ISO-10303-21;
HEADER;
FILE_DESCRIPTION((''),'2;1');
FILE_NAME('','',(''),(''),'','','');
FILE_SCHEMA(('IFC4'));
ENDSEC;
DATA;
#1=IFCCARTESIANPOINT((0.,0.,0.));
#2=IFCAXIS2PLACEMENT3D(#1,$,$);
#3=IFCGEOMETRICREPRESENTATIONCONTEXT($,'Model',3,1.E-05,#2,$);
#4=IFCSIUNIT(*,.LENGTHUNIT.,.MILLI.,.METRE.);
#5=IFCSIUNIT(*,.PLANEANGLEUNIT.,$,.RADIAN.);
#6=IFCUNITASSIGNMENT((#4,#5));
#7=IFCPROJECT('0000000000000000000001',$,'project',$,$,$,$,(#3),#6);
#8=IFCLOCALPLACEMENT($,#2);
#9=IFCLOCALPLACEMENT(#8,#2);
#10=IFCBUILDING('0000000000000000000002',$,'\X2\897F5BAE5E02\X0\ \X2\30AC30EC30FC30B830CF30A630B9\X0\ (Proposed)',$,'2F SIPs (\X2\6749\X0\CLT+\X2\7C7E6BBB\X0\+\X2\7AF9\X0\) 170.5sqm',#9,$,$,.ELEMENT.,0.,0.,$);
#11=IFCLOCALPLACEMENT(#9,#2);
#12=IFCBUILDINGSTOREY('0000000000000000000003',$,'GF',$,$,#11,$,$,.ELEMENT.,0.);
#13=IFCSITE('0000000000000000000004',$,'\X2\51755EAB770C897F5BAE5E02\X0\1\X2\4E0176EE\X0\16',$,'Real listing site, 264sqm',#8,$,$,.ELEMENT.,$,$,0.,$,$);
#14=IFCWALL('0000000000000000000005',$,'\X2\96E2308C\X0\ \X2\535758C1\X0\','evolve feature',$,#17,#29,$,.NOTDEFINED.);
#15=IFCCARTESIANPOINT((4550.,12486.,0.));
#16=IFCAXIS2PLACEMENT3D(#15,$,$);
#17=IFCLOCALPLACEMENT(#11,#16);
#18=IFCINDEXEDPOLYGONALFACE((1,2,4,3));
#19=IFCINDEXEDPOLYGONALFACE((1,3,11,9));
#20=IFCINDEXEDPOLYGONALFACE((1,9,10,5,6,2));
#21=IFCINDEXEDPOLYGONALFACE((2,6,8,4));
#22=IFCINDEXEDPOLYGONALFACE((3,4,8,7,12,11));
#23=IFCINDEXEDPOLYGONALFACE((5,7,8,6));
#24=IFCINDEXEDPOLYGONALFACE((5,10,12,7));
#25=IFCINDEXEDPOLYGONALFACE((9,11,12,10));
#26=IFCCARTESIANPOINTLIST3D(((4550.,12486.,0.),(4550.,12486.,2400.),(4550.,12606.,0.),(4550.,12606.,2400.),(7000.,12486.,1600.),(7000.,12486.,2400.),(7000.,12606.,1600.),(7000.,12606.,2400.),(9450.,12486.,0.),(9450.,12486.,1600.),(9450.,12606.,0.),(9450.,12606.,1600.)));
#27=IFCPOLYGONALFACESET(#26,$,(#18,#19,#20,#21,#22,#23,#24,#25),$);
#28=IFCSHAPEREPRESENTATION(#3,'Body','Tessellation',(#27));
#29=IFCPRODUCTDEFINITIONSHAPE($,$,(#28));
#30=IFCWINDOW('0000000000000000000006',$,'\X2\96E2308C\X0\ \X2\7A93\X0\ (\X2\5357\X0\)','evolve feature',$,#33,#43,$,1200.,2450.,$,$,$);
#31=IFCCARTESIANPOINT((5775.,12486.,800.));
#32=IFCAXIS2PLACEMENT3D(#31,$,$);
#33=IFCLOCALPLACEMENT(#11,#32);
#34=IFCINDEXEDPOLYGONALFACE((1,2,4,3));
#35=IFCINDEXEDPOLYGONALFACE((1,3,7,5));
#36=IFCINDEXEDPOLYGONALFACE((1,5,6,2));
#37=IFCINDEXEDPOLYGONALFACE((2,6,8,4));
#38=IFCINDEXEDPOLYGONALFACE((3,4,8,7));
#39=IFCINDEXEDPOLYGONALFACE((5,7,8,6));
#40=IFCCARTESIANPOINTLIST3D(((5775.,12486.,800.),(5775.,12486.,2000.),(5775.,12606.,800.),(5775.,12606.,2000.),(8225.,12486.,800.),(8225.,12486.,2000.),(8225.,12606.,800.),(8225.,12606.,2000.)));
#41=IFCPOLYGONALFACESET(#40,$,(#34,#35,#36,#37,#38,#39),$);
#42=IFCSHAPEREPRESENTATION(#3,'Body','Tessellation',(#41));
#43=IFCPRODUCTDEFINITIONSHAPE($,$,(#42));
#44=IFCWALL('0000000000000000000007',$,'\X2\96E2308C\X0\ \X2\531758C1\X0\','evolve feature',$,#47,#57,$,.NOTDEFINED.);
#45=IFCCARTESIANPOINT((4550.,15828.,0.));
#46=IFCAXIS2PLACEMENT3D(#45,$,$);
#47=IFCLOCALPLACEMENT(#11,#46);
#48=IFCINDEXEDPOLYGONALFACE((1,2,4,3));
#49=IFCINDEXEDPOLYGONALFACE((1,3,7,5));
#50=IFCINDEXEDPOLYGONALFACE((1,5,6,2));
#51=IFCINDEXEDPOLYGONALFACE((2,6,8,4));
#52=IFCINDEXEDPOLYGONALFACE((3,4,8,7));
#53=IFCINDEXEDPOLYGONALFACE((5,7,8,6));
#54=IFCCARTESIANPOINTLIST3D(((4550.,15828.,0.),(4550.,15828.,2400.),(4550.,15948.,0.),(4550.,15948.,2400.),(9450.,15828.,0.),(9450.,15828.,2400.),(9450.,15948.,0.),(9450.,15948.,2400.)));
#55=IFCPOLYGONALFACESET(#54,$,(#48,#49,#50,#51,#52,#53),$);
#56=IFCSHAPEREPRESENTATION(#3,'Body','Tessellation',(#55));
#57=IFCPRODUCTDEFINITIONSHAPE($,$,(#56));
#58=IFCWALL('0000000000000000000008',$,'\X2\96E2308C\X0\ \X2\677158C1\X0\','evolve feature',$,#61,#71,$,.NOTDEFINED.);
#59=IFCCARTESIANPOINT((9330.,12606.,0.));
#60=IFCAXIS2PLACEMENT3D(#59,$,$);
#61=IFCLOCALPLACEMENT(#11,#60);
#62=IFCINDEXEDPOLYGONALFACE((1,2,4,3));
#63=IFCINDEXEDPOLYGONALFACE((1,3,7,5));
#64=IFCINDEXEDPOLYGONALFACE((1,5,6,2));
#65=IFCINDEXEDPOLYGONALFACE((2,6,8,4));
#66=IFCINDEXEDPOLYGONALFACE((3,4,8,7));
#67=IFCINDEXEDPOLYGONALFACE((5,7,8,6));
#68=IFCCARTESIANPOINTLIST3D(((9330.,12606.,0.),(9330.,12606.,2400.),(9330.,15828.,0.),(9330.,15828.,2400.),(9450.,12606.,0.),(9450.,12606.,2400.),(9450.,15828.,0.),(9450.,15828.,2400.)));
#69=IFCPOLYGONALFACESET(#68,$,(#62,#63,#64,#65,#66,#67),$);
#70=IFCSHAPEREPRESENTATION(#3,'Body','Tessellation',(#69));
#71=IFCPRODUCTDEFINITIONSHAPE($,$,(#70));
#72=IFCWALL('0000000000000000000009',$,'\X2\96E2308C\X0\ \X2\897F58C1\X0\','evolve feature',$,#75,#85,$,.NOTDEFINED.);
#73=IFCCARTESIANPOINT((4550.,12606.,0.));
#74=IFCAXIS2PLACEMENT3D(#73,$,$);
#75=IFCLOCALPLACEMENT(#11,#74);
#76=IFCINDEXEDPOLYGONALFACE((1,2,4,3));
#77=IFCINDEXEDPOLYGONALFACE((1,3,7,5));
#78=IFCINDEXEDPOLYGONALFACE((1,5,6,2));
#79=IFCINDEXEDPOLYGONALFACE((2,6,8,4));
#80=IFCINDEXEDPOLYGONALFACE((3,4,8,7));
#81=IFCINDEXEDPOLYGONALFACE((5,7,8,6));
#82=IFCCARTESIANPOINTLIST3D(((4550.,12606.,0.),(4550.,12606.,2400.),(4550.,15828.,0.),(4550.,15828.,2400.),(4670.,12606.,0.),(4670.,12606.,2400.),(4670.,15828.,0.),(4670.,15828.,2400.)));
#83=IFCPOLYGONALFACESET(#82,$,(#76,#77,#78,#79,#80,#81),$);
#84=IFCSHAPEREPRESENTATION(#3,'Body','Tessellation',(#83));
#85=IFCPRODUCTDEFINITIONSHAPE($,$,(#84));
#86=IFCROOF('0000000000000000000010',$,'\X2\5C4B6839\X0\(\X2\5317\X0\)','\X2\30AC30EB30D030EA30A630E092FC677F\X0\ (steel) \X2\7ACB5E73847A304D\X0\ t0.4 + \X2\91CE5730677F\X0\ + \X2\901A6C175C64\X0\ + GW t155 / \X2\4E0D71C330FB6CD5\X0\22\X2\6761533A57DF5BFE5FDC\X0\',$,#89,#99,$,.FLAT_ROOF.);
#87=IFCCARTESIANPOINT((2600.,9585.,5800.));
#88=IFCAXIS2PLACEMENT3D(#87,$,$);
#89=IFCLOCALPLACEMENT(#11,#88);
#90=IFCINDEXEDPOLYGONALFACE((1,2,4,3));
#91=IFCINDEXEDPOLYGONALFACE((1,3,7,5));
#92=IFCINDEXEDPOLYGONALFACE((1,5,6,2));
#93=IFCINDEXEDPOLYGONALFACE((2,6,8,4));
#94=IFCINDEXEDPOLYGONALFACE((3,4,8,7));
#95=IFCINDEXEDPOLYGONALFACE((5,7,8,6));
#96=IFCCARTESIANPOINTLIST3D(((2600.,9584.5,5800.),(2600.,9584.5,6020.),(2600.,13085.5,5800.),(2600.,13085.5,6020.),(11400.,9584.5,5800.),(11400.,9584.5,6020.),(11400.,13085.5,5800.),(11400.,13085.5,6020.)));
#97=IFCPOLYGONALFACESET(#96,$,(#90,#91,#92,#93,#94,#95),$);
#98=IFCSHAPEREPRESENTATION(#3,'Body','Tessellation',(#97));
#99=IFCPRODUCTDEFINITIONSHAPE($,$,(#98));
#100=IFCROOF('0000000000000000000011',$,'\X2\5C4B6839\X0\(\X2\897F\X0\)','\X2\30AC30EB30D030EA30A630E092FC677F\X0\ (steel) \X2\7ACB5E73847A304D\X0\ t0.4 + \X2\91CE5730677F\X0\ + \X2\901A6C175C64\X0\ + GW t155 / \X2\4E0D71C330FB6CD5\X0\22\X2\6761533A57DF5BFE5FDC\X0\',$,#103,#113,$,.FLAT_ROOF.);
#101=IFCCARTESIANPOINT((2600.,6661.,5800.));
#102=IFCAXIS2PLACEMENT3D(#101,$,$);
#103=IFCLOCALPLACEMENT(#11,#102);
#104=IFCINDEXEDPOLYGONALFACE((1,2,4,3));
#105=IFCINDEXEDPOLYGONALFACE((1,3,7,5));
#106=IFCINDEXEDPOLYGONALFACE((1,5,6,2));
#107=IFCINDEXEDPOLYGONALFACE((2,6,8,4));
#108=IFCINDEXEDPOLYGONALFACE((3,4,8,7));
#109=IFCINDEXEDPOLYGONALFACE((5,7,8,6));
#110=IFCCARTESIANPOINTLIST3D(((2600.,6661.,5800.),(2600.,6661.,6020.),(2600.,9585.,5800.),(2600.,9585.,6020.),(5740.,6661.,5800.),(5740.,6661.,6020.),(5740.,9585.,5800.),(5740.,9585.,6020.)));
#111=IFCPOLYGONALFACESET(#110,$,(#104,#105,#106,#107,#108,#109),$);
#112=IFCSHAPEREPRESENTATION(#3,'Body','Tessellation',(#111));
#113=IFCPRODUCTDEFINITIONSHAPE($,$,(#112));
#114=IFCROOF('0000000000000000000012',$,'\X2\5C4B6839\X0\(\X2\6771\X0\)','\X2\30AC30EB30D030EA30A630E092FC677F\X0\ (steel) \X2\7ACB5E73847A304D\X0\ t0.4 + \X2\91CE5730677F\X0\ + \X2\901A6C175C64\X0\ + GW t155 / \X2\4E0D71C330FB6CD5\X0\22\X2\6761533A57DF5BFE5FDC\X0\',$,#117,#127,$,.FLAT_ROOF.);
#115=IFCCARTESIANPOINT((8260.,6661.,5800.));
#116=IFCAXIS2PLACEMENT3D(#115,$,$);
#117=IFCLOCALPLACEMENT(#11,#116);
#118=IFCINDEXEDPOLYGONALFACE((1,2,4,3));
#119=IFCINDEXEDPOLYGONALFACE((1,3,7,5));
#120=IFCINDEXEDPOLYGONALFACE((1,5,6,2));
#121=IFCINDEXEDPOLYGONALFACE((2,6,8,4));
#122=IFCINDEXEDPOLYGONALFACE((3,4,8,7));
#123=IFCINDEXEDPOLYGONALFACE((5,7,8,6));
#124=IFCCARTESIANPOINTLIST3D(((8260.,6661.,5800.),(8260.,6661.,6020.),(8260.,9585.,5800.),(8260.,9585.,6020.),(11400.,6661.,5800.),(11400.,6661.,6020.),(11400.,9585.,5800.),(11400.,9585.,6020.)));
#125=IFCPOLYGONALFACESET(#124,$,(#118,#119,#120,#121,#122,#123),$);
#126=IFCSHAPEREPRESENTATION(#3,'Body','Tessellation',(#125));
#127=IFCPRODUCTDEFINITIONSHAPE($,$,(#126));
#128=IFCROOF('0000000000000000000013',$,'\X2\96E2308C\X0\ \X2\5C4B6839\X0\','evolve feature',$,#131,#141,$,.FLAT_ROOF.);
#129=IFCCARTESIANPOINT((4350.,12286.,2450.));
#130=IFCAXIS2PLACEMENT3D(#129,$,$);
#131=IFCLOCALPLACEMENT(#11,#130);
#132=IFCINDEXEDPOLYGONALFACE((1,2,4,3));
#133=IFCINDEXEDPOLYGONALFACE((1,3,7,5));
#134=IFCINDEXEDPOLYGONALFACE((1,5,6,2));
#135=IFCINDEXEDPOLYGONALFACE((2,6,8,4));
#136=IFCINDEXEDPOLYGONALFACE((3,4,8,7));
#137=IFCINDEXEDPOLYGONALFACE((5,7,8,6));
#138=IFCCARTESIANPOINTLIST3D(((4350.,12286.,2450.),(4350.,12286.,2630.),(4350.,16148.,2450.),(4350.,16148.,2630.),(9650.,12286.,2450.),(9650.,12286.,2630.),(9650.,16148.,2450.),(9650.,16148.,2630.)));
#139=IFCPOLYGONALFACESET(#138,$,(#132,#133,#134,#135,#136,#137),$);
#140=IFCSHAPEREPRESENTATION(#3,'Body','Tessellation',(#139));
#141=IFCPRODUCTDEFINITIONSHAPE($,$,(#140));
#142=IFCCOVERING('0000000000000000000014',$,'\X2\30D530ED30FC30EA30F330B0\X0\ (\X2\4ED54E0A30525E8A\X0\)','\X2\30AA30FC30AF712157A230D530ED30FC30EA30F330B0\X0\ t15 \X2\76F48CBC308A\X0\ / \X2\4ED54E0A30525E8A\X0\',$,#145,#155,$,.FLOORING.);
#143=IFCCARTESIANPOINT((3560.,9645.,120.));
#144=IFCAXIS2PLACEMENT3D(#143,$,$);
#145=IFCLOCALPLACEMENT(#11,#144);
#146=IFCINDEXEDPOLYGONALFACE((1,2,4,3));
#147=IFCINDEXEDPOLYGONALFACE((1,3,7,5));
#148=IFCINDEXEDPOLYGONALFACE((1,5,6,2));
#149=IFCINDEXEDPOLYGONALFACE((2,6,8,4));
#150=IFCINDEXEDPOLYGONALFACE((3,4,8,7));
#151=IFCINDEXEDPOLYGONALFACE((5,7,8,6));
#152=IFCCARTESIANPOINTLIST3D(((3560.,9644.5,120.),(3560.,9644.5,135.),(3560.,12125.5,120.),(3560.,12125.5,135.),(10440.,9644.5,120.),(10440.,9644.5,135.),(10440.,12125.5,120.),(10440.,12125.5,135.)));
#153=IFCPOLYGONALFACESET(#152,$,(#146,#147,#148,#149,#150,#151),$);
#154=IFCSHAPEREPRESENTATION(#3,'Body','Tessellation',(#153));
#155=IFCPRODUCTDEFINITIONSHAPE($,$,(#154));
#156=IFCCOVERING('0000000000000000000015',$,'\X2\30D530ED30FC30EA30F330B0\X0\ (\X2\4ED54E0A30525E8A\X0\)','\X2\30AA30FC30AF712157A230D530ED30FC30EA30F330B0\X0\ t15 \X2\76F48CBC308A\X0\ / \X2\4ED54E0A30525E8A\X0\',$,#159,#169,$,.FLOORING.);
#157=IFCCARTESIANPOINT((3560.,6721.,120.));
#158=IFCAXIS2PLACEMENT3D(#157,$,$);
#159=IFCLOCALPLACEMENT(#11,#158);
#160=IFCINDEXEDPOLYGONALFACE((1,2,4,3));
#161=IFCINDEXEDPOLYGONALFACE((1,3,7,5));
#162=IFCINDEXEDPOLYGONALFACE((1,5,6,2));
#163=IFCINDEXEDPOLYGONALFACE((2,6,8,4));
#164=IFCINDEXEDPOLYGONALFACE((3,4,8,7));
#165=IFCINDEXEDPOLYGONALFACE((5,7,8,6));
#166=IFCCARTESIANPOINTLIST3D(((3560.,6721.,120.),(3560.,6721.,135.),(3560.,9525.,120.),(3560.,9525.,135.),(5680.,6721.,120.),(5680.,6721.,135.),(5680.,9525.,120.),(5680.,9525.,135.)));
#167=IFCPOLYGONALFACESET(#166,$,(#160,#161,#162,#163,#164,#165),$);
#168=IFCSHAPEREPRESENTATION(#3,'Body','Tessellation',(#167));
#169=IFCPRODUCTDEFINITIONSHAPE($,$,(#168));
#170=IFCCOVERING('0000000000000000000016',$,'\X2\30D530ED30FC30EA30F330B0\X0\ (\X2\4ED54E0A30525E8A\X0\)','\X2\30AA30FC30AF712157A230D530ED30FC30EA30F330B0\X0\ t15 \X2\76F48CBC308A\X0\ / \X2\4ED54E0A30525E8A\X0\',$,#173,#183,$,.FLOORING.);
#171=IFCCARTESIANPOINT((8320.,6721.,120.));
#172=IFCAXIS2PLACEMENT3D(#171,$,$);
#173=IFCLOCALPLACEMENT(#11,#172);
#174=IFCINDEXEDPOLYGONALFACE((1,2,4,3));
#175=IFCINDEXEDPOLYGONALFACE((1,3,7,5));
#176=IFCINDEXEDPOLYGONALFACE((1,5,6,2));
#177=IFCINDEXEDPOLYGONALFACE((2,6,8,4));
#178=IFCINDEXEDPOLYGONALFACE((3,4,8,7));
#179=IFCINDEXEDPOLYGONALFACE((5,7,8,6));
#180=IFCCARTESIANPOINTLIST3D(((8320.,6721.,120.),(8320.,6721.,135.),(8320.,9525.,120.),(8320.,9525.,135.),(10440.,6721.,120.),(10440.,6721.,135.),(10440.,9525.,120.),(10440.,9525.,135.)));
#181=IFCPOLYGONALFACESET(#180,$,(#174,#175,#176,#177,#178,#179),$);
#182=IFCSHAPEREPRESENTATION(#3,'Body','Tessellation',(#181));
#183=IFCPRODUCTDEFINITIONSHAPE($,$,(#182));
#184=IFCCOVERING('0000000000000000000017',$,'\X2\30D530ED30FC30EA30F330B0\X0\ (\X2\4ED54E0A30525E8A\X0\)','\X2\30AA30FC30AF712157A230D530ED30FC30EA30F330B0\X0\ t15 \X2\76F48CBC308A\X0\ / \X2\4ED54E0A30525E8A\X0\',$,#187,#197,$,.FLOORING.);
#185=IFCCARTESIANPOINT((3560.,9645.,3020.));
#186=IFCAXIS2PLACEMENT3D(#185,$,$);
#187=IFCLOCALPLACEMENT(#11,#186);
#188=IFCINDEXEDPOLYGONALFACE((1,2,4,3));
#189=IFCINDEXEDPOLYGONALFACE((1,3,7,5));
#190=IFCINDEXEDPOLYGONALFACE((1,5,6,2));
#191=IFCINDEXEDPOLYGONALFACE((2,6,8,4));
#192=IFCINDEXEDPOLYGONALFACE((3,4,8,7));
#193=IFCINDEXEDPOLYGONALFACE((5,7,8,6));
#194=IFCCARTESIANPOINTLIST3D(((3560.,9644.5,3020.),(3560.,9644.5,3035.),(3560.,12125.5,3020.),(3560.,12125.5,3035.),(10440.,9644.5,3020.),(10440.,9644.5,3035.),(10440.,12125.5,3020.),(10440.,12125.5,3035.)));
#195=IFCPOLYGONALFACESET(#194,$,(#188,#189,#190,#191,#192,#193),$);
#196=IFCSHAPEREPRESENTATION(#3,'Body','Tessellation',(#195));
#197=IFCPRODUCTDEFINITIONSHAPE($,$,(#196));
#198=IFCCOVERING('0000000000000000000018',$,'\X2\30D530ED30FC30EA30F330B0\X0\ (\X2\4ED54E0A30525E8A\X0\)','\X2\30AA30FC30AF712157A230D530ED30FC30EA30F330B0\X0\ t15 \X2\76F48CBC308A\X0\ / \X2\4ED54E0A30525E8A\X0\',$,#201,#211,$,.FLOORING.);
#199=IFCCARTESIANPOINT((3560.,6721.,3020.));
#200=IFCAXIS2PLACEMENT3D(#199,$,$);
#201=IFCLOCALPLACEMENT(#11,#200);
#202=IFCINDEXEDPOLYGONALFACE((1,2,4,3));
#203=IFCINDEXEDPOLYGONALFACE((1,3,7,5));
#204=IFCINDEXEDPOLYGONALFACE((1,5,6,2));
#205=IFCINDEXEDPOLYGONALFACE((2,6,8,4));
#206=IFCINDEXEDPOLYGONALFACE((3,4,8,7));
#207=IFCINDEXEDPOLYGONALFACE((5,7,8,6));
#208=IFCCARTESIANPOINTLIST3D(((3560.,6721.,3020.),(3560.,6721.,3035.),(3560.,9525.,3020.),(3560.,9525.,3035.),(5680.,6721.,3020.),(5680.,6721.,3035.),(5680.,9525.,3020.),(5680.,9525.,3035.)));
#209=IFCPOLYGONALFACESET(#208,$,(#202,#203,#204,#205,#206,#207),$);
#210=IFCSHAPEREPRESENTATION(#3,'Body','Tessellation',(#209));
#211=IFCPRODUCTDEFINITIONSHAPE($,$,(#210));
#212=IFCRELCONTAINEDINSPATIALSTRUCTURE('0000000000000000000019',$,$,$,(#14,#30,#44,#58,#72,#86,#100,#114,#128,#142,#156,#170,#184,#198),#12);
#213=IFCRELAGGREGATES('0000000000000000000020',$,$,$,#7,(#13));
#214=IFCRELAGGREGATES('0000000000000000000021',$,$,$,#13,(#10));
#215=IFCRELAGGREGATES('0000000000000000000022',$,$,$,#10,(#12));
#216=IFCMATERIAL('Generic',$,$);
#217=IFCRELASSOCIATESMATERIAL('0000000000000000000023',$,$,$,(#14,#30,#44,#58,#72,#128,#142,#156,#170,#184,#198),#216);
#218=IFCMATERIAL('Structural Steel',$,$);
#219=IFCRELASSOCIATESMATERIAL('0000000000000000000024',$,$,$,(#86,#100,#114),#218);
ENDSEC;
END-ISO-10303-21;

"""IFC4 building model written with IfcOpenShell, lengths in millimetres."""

from ifc_helpers import new_model, si_unit, frame, frame_2d, origin, place, context, project, spatial, rectangle, extrude, material, element, fill, save


model = new_model("IFC4")

# Units and contexts
model_context = context("Model", 3, precision=1e-05, world=origin())
ifc_project = project(units=[si_unit("LENGTHUNIT", "METRE", prefix="MILLI"), si_unit("PLANEANGLEUNIT", "RADIAN")], contexts=[model_context])

# Site, building, storey
site_placement = place(None, origin())
site = spatial("IfcSite", under=ifc_project, at=site_placement, Name="兵庫県西宮市1丁目16", ObjectType="Real listing site, 264sqm", CompositionType="ELEMENT", RefElevation=0.0)
building_placement = place(site_placement, origin())
building = spatial("IfcBuilding", under=site, at=building_placement, Name="西宮市 ガレージハウス (Proposed)", ObjectType="2F SIPs (杉CLT+籾殻+竹) 170.5sqm", CompositionType="ELEMENT", ElevationOfRefHeight=0.0, ElevationOfTerrain=0.0)
storey_placement = place(building_placement, origin())
storey = spatial("IfcBuildingStorey", under=building, at=storey_placement, Name="GF", CompositionType="ELEMENT", Elevation=0.0)

# Shared definitions
ifc_material_1 = material(Name="Generic")

# Wall, opening, window
wall_1_placement = place(storey_placement, frame((4550.0, 12486.0, 0.0)))
wall_1 = element("IfcWall", 1, at=wall_1_placement, inside=storey, material=ifc_material_1, Name="離れ 南壁", Description="evolve feature", PredefinedType="NOTDEFINED", context=model_context, shape_type="SweptSolid", body=[
    extrude(rectangle(XDim=4900.0, YDim=120.0, at=frame_2d((2450.0, 60.0))), frame((4550.0, 12486.0, 0.0)), (0.0, 0.0, 1.0), 2400.0),
])
opening_1_placement = place(storey_placement, frame((5775.0, 12486.0, 800.0)))
opening_1 = element("IfcOpeningElement", 2, at=opening_1_placement, cuts=wall_1, PredefinedType="NOTDEFINED", context=model_context, shape_type="SweptSolid", body=[
    extrude(rectangle(XDim=2450.0, YDim=120.0, at=frame_2d((1225.0, 60.0))), frame((5775.0, 12486.0, 800.0)), (0.0, 0.0, 1.0), 1200.0),
])
window_1_placement = place(storey_placement, frame((5775.0, 12486.0, 800.0)))
window_1 = element("IfcWindow", 3, at=window_1_placement, inside=storey, material=ifc_material_1, Name="離れ 窓 (南)", Description="evolve feature", OverallHeight=1200.0, OverallWidth=2450.0, context=model_context, shape_type="SweptSolid", body=[
    extrude(rectangle(XDim=2450.0, YDim=120.0, at=frame_2d((1225.0, 60.0))), frame((5775.0, 12486.0, 800.0)), (0.0, 0.0, 1.0), 1200.0),
])
fill(opening_1, window_1)

# Walls
wall_2_placement = place(storey_placement, frame((4550.0, 15828.0, 0.0)))
element("IfcWall", 4, at=wall_2_placement, inside=storey, material=ifc_material_1, Name="離れ 北壁", Description="evolve feature", PredefinedType="NOTDEFINED", context=model_context, shape_type="SweptSolid", body=[
    extrude(rectangle(XDim=4900.0, YDim=120.0, at=frame_2d((2450.0, 60.0))), frame((4550.0, 15828.0, 0.0)), (0.0, 0.0, 1.0), 2400.0),
])
wall_3_placement = place(storey_placement, frame((9330.0, 12606.0, 0.0)))
element("IfcWall", 5, at=wall_3_placement, inside=storey, material=ifc_material_1, Name="離れ 東壁", Description="evolve feature", PredefinedType="NOTDEFINED", context=model_context, shape_type="SweptSolid", body=[
    extrude(rectangle(XDim=120.0, YDim=3222.0, at=frame_2d((60.0, 1611.0))), frame((9330.0, 12606.0, 0.0)), (0.0, 0.0, 1.0), 2400.0),
])
wall_4_placement = place(storey_placement, frame((4550.0, 12606.0, 0.0)))
element("IfcWall", 6, at=wall_4_placement, inside=storey, material=ifc_material_1, Name="離れ 西壁", Description="evolve feature", PredefinedType="NOTDEFINED", context=model_context, shape_type="SweptSolid", body=[
    extrude(rectangle(XDim=120.0, YDim=3222.0, at=frame_2d((60.0, 1611.0))), frame((4550.0, 12606.0, 0.0)), (0.0, 0.0, 1.0), 2400.0),
])

# Roofs
ifc_material_2 = material(Name="Structural Steel")
for number, where, name in (
    (7, (2600.0, 9585.0, 5800.0), "屋根(北)"),
):
    element("IfcRoof", number, at=place(storey_placement, frame(where)), inside=storey, material=ifc_material_2, Name=name, Description="ガルバリウム鋼板 (steel) 立平葺き t0.4 + 野地板 + 通気層 + GW t155 / 不燃・法22条区域対応", PredefinedType="FLAT_ROOF", context=model_context, shape_type="SweptSolid", body=[
        extrude(rectangle(XDim=8800.0, YDim=3501.0, at=frame_2d((4400.0, 1750.0))), frame((2600.0, 9585.0, 5800.0)), (0.0, 0.0, 1.0), 220.0),
    ])
roof_1_placement = place(storey_placement, frame((2600.0, 6661.0, 5800.0)))
element("IfcRoof", 8, at=roof_1_placement, inside=storey, material=ifc_material_2, Name="屋根(西)", Description="ガルバリウム鋼板 (steel) 立平葺き t0.4 + 野地板 + 通気層 + GW t155 / 不燃・法22条区域対応", PredefinedType="FLAT_ROOF", context=model_context, shape_type="SweptSolid", body=[
    extrude(rectangle(XDim=3140.0, YDim=2924.0, at=frame_2d((1570.0, 1462.0))), frame((2600.0, 6661.0, 5800.0)), (0.0, 0.0, 1.0), 220.0),
])
roof_2_placement = place(storey_placement, frame((8260.0, 6661.0, 5800.0)))
element("IfcRoof", 9, at=roof_2_placement, inside=storey, material=ifc_material_2, Name="屋根(東)", Description="ガルバリウム鋼板 (steel) 立平葺き t0.4 + 野地板 + 通気層 + GW t155 / 不燃・法22条区域対応", PredefinedType="FLAT_ROOF", context=model_context, shape_type="SweptSolid", body=[
    extrude(rectangle(XDim=3140.0, YDim=2924.0, at=frame_2d((1570.0, 1462.0))), frame((8260.0, 6661.0, 5800.0)), (0.0, 0.0, 1.0), 220.0),
])
roof_3_placement = place(storey_placement, frame((4350.0, 12286.0, 2450.0)))
element("IfcRoof", 10, at=roof_3_placement, inside=storey, material=ifc_material_1, Name="離れ 屋根", Description="evolve feature", PredefinedType="FLAT_ROOF", context=model_context, shape_type="SweptSolid", body=[
    extrude(rectangle(XDim=5300.0, YDim=3862.0, at=frame_2d((2650.0, 1931.0))), frame((4350.0, 12286.0, 2450.0)), (0.0, 0.0, 1.0), 180.0),
])

# Coverings
covering_1_placement = place(storey_placement, frame((3560.0, 9645.0, 120.0)))
element("IfcCovering", 11, at=covering_1_placement, inside=storey, material=ifc_material_1, Name="フローリング (仕上げ床)", Description="オーク無垢フローリング t15 直貼り / 仕上げ床", PredefinedType="FLOORING", context=model_context, shape_type="SweptSolid", body=[
    extrude(rectangle(XDim=6880.0, YDim=2481.0, at=frame_2d((3440.0, 1240.0))), frame((3560.0, 9645.0, 120.0)), (0.0, 0.0, 1.0), 15.0),
])
covering_2_placement = place(storey_placement, frame((3560.0, 6721.0, 120.0)))
element("IfcCovering", 12, at=covering_2_placement, inside=storey, material=ifc_material_1, Name="フローリング (仕上げ床)", Description="オーク無垢フローリング t15 直貼り / 仕上げ床", PredefinedType="FLOORING", context=model_context, shape_type="SweptSolid", body=[
    extrude(rectangle(XDim=2120.0, YDim=2804.0, at=frame_2d((1060.0, 1402.0))), frame((3560.0, 6721.0, 120.0)), (0.0, 0.0, 1.0), 15.0),
])
covering_3_placement = place(storey_placement, frame((8320.0, 6721.0, 120.0)))
element("IfcCovering", 13, at=covering_3_placement, inside=storey, material=ifc_material_1, Name="フローリング (仕上げ床)", Description="オーク無垢フローリング t15 直貼り / 仕上げ床", PredefinedType="FLOORING", context=model_context, shape_type="SweptSolid", body=[
    extrude(rectangle(XDim=2120.0, YDim=2804.0, at=frame_2d((1060.0, 1402.0))), frame((8320.0, 6721.0, 120.0)), (0.0, 0.0, 1.0), 15.0),
])
covering_4_placement = place(storey_placement, frame((3560.0, 9645.0, 3020.0)))
element("IfcCovering", 14, at=covering_4_placement, inside=storey, material=ifc_material_1, Name="フローリング (仕上げ床)", Description="オーク無垢フローリング t15 直貼り / 仕上げ床", PredefinedType="FLOORING", context=model_context, shape_type="SweptSolid", body=[
    extrude(rectangle(XDim=6880.0, YDim=2481.0, at=frame_2d((3440.0, 1240.0))), frame((3560.0, 9645.0, 3020.0)), (0.0, 0.0, 1.0), 15.0),
])
covering_5_placement = place(storey_placement, frame((3560.0, 6721.0, 3020.0)))
element("IfcCovering", 15, at=covering_5_placement, inside=storey, material=ifc_material_1, Name="フローリング (仕上げ床)", Description="オーク無垢フローリング t15 直貼り / 仕上げ床", PredefinedType="FLOORING", context=model_context, shape_type="SweptSolid", body=[
    extrude(rectangle(XDim=2120.0, YDim=2804.0, at=frame_2d((1060.0, 1402.0))), frame((3560.0, 6721.0, 3020.0)), (0.0, 0.0, 1.0), 15.0),
])

save(model, "model.ifc")
